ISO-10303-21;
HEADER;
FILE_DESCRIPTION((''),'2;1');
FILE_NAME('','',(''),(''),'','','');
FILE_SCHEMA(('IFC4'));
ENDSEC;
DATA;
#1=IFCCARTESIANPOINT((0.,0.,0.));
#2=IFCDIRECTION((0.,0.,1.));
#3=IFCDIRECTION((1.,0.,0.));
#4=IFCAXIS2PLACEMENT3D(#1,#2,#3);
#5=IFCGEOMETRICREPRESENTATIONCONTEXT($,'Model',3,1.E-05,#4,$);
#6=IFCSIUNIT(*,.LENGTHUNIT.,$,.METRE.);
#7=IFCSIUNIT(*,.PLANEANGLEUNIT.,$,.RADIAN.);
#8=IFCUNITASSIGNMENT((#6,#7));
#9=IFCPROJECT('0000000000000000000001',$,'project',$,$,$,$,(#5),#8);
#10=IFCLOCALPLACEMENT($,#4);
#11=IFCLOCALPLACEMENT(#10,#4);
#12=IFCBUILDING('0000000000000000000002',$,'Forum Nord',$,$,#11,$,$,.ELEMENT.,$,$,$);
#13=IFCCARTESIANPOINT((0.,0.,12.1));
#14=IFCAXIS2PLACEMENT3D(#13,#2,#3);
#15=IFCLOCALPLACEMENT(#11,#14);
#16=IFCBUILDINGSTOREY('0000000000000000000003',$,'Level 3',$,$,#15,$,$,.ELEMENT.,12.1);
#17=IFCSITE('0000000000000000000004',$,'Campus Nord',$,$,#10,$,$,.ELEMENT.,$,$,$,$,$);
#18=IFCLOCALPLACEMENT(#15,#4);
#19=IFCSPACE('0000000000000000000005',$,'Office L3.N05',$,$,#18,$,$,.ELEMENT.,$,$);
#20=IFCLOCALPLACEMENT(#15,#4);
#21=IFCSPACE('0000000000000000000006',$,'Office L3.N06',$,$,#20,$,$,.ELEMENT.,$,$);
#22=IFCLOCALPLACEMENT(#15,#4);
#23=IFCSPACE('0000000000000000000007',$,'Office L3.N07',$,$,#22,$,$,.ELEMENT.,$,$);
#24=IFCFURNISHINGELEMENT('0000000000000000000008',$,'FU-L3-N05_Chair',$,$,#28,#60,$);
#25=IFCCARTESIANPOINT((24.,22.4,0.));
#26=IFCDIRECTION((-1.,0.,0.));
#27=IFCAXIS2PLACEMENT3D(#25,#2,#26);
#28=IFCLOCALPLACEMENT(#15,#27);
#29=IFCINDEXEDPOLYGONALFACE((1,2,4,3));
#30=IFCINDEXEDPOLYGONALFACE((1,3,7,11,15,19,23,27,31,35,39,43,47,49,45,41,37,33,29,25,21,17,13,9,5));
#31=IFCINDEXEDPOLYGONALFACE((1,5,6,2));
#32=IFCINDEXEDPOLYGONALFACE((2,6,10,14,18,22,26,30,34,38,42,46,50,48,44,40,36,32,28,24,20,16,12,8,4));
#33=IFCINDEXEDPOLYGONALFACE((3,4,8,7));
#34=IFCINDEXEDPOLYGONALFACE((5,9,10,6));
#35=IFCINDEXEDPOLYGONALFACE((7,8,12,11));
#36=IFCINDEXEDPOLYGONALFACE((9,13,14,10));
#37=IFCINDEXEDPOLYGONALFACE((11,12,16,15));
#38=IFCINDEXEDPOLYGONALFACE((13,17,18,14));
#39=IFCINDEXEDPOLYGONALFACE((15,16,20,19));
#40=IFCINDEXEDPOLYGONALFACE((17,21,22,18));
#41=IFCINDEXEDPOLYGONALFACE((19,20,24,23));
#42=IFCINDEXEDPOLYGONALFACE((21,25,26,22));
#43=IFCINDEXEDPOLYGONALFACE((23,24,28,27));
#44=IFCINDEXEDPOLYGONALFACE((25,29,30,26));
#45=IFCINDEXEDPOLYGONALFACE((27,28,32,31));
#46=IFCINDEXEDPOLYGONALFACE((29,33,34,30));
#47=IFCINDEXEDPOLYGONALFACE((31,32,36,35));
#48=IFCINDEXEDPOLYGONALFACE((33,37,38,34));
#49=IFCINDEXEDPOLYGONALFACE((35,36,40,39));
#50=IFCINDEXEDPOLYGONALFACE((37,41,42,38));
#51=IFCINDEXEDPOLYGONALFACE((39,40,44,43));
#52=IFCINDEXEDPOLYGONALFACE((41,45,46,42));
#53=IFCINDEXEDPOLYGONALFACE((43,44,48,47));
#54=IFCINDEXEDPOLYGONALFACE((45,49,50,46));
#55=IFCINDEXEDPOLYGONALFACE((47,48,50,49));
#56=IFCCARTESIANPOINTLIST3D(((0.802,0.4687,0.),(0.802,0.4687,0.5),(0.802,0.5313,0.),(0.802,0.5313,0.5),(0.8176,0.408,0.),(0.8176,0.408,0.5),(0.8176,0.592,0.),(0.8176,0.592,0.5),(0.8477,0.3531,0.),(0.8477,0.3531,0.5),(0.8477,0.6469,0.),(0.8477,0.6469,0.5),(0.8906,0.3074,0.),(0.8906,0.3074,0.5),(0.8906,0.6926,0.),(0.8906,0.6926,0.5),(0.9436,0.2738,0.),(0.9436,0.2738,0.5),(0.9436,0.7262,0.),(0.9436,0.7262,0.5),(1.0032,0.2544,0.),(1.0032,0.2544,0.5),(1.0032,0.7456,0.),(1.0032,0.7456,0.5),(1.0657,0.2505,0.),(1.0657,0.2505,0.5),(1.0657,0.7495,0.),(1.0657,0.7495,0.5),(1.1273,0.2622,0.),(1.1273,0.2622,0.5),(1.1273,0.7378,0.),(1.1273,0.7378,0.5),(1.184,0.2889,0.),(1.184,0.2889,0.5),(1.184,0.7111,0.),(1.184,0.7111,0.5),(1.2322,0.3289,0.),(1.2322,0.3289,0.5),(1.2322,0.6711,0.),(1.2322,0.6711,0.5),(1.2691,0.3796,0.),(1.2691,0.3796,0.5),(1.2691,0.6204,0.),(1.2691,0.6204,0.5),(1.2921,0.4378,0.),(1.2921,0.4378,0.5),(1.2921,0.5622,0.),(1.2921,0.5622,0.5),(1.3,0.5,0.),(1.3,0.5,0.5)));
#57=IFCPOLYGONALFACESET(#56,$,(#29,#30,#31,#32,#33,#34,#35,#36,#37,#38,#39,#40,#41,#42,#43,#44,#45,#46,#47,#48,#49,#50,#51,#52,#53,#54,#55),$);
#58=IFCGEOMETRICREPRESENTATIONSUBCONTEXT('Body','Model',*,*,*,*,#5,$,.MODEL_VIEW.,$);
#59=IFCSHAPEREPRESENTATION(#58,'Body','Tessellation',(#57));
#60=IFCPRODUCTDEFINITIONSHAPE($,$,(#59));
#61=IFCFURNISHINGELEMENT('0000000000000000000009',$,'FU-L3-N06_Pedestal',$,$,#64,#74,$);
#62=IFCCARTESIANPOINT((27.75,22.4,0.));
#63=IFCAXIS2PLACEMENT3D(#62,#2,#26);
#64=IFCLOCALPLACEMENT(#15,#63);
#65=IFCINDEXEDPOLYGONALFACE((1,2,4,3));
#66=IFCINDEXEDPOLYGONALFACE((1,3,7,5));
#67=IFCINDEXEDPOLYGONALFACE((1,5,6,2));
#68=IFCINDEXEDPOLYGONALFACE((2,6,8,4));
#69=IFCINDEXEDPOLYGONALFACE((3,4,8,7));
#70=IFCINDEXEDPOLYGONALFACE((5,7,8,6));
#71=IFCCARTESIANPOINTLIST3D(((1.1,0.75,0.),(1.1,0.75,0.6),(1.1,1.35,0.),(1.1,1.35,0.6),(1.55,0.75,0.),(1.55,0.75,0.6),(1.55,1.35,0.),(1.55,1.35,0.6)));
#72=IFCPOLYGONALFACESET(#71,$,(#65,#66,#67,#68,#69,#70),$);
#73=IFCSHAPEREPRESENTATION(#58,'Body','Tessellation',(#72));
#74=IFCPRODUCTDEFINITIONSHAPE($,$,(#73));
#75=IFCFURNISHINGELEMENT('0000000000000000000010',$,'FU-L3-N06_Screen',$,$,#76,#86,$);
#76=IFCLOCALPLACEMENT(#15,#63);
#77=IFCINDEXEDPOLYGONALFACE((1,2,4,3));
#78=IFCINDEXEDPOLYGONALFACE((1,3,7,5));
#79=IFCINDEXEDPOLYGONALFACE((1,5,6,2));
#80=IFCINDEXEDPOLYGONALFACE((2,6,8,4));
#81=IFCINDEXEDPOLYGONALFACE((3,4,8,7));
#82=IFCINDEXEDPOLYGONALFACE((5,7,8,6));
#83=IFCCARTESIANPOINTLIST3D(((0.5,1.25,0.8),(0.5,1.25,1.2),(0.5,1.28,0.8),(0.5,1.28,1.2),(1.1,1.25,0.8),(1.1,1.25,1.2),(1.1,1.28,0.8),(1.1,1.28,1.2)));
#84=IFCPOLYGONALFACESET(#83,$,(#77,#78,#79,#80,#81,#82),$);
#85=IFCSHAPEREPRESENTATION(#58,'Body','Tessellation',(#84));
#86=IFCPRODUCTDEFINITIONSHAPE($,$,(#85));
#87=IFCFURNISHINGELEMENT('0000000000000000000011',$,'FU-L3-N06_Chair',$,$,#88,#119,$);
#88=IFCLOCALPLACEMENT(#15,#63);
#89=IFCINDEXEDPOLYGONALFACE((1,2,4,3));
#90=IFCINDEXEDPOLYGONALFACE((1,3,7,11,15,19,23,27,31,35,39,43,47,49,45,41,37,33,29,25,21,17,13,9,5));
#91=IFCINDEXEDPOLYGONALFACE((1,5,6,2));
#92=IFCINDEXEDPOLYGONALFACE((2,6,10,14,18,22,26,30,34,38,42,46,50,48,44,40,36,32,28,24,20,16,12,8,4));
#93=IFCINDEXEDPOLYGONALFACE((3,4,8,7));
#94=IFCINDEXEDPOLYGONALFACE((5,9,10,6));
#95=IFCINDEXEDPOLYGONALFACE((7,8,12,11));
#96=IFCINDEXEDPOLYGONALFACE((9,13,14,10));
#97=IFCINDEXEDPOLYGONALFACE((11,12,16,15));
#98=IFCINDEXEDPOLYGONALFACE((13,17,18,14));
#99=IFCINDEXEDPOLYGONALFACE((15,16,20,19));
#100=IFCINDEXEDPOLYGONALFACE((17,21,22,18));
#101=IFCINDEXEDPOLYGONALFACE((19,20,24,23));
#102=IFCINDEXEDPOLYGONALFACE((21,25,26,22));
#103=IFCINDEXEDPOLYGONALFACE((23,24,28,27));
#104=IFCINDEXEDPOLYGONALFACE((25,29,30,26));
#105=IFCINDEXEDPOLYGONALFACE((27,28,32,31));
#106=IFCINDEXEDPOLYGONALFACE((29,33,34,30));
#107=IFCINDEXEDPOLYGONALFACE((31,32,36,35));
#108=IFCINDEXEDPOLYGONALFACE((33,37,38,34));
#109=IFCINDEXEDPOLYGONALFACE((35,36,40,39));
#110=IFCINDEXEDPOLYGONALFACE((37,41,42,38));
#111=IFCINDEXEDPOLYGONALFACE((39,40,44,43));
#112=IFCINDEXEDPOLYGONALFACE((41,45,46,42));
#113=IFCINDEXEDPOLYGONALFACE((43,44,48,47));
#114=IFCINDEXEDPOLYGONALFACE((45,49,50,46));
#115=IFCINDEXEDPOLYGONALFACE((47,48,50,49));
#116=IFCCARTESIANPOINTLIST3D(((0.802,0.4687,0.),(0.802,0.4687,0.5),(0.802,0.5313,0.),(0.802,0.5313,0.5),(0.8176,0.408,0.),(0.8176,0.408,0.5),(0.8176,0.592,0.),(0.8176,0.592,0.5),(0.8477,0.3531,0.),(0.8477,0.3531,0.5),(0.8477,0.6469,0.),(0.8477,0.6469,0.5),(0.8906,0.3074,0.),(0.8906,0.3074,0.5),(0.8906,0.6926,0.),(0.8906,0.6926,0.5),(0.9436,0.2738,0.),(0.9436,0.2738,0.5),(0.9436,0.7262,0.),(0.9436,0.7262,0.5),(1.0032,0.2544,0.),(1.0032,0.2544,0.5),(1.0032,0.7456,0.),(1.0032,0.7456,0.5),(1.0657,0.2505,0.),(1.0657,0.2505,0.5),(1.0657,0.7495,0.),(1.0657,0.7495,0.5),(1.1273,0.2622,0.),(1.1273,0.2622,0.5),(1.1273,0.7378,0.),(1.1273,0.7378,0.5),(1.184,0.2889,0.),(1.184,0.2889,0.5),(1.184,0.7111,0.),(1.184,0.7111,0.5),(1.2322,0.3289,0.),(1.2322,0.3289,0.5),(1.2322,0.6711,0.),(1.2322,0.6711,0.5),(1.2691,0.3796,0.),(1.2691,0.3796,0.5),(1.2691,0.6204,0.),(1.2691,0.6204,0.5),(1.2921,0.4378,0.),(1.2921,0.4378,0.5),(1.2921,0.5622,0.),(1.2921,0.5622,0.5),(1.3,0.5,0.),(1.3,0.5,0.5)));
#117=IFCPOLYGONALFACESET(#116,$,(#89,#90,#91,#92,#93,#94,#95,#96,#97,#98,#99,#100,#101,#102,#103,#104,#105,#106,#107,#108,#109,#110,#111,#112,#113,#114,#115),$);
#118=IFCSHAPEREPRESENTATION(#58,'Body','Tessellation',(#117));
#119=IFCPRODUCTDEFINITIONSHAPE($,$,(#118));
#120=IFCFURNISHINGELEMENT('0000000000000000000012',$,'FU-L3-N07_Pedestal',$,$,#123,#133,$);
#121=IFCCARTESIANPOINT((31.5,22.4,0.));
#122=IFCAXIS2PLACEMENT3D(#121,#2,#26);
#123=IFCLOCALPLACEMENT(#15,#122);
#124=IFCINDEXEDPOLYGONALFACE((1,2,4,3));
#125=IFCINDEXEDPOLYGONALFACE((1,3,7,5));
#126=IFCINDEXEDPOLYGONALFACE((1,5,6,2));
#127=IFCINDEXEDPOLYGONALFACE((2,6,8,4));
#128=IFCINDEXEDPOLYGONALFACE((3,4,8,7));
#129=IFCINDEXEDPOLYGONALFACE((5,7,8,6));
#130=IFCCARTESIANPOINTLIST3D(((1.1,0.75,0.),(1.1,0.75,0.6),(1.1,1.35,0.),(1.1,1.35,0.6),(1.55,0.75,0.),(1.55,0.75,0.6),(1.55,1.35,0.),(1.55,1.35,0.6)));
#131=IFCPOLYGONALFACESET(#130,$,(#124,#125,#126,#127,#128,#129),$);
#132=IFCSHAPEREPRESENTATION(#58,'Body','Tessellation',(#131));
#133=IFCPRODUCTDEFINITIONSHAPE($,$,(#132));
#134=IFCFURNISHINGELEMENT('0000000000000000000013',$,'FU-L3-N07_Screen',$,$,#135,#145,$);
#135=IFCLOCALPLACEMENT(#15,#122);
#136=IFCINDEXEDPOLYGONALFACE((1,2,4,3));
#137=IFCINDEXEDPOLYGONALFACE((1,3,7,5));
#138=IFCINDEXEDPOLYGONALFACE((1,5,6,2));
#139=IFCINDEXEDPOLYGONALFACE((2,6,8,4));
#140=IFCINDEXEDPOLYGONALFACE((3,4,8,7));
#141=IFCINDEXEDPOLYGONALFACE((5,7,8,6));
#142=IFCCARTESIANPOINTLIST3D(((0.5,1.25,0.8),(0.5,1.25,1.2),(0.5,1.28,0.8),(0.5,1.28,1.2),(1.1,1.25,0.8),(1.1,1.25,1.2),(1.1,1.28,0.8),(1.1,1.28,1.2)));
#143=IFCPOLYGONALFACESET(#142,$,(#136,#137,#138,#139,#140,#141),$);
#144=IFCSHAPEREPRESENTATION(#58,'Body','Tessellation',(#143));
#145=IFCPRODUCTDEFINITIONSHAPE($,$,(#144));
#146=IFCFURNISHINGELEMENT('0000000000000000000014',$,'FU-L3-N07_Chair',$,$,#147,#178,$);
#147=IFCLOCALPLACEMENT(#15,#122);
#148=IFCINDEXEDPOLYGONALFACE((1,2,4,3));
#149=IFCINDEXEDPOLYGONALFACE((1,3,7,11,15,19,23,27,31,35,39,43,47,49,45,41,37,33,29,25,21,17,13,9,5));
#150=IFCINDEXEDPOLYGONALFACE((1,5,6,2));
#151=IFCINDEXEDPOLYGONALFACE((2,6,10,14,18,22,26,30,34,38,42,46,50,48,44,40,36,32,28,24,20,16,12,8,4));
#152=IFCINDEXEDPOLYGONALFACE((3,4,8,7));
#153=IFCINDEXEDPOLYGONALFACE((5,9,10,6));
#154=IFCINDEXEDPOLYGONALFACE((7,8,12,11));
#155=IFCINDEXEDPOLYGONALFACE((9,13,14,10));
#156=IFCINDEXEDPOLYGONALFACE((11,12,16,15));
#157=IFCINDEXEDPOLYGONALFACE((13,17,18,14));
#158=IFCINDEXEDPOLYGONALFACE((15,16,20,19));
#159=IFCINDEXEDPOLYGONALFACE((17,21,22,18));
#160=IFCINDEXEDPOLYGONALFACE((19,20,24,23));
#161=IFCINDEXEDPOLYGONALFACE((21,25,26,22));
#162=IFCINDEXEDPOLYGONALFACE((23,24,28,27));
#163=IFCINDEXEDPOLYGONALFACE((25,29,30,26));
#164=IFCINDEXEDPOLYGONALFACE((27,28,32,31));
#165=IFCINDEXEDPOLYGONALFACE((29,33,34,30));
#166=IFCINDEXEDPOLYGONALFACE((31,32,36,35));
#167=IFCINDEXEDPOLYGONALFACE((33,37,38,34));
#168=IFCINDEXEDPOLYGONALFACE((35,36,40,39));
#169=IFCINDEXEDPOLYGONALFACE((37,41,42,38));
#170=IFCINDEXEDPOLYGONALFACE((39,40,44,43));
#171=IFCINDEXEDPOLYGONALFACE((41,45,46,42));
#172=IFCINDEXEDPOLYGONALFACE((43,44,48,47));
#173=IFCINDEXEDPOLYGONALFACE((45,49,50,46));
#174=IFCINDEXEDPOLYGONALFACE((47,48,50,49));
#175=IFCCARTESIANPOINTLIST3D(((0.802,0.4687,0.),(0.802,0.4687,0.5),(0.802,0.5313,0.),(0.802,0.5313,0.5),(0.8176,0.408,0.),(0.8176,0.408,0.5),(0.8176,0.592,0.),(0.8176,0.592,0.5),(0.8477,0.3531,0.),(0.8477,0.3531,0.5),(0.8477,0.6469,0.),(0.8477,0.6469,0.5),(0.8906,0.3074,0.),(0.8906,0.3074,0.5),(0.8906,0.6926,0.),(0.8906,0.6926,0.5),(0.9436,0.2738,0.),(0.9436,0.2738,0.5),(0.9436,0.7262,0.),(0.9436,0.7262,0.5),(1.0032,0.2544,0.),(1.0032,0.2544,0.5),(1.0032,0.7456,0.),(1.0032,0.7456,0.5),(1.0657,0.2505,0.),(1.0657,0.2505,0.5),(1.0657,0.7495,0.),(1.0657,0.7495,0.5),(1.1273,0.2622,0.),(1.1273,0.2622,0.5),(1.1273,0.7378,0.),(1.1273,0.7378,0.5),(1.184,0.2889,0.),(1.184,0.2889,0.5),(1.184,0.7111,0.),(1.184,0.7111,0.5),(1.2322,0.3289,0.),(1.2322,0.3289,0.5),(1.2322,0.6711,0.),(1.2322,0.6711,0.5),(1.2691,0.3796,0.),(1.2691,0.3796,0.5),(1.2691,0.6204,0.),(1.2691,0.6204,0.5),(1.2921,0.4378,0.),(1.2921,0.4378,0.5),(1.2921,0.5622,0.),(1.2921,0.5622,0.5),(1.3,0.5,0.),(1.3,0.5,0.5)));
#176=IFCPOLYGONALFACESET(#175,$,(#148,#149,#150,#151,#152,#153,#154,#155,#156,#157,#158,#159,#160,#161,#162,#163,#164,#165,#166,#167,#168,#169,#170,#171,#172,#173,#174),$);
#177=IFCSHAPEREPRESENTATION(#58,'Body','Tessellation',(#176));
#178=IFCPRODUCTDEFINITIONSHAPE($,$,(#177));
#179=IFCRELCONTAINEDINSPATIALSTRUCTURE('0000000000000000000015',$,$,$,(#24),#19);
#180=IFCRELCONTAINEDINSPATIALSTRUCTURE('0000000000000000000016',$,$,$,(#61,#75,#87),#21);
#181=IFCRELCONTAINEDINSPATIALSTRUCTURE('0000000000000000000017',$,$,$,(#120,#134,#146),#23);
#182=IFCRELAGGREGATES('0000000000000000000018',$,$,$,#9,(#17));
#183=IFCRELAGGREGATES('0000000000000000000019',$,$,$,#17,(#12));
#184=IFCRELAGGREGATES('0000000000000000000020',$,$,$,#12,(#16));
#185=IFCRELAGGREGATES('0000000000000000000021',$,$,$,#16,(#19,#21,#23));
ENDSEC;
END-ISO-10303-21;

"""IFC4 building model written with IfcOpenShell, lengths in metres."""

from ifc_helpers import new_model, si_unit, frame, frame_2d, origin_with_axes, place, context, subcontext, project, spatial, rectangle, circle, extrude, element, save


model = new_model("IFC4")

# Units and contexts
model_context = context("Model", 3, precision=1e-05, world=origin_with_axes())
body_context = subcontext(model_context, "Body", "Model", "MODEL_VIEW")
ifc_project = project(units=[si_unit("LENGTHUNIT", "METRE"), si_unit("PLANEANGLEUNIT", "RADIAN")], contexts=[model_context])

# Site, building, storey
site_placement = place(None, origin_with_axes())
site = spatial("IfcSite", under=ifc_project, at=site_placement, Name="Campus Nord", CompositionType="ELEMENT")
building_placement = place(site_placement, origin_with_axes())
building = spatial("IfcBuilding", under=site, at=building_placement, Name="Forum Nord", CompositionType="ELEMENT")
storey_placement = place(building_placement, frame((0.0, 0.0, 12.1), z_axis=(0.0, 0.0, 1.0), x_axis=(1.0, 0.0, 0.0)))
storey = spatial("IfcBuildingStorey", under=building, at=storey_placement, Name="Level 3", CompositionType="ELEMENT", Elevation=12.1)

# Shared definitions
space_1_placement = place(storey_placement, origin_with_axes())
space_1 = spatial("IfcSpace", under=storey, at=space_1_placement, Name="Office L3.N05", CompositionType="ELEMENT")

# Furnishing element
furnishing_1_placement = place(storey_placement, frame((24.0, 22.4, 0.0), z_axis=(0.0, 0.0, 1.0), x_axis=(-1.0, 0.0, 0.0)))
element("IfcFurnishingElement", 1, at=furnishing_1_placement, inside=space_1, Name="FU-L3-N05_Chair", context=body_context, shape_type="SweptSolid", body=[
    extrude(circle(Radius=0.25, at=frame_2d((1.05, 0.5), x_axis=(1.0, 0.0))), origin_with_axes(), (0.0, 0.0, 1.0), 0.5),
])

# Shared definitions
space_2_placement = place(storey_placement, origin_with_axes())
space_2 = spatial("IfcSpace", under=storey, at=space_2_placement, Name="Office L3.N06", CompositionType="ELEMENT")

# Furnishing elements
furnishing_2_placement = place(storey_placement, frame((27.75, 22.4, 0.0), z_axis=(0.0, 0.0, 1.0), x_axis=(-1.0, 0.0, 0.0)))
element("IfcFurnishingElement", 2, at=furnishing_2_placement, inside=space_2, Name="FU-L3-N06_Pedestal", context=body_context, shape_type="SweptSolid", body=[
    extrude(rectangle(XDim=0.45, YDim=0.6, at=frame_2d((1.325, 1.05), x_axis=(1.0, 0.0))), origin_with_axes(), (0.0, 0.0, 1.0), 0.6),
])
furnishing_3_placement = place(storey_placement, frame((27.75, 22.4, 0.0), z_axis=(0.0, 0.0, 1.0), x_axis=(-1.0, 0.0, 0.0)))
element("IfcFurnishingElement", 3, at=furnishing_3_placement, inside=space_2, Name="FU-L3-N06_Screen", context=body_context, shape_type="SweptSolid", body=[
    extrude(rectangle(XDim=0.6, YDim=0.03, at=frame_2d((0.8, 1.265), x_axis=(1.0, 0.0))), frame((0.0, 0.0, 0.8), z_axis=(0.0, 0.0, 1.0), x_axis=(1.0, 0.0, 0.0)), (0.0, 0.0, 1.0), 0.4),
])
furnishing_4_placement = place(storey_placement, frame((27.75, 22.4, 0.0), z_axis=(0.0, 0.0, 1.0), x_axis=(-1.0, 0.0, 0.0)))
element("IfcFurnishingElement", 4, at=furnishing_4_placement, inside=space_2, Name="FU-L3-N06_Chair", context=body_context, shape_type="SweptSolid", body=[
    extrude(circle(Radius=0.25, at=frame_2d((1.05, 0.5), x_axis=(1.0, 0.0))), origin_with_axes(), (0.0, 0.0, 1.0), 0.5),
])

# Shared definitions
space_3_placement = place(storey_placement, origin_with_axes())
space_3 = spatial("IfcSpace", under=storey, at=space_3_placement, Name="Office L3.N07", CompositionType="ELEMENT")

# Furnishing elements
furnishing_5_placement = place(storey_placement, frame((31.5, 22.4, 0.0), z_axis=(0.0, 0.0, 1.0), x_axis=(-1.0, 0.0, 0.0)))
element("IfcFurnishingElement", 5, at=furnishing_5_placement, inside=space_3, Name="FU-L3-N07_Pedestal", context=body_context, shape_type="SweptSolid", body=[
    extrude(rectangle(XDim=0.45, YDim=0.6, at=frame_2d((1.325, 1.05), x_axis=(1.0, 0.0))), origin_with_axes(), (0.0, 0.0, 1.0), 0.6),
])
furnishing_6_placement = place(storey_placement, frame((31.5, 22.4, 0.0), z_axis=(0.0, 0.0, 1.0), x_axis=(-1.0, 0.0, 0.0)))
element("IfcFurnishingElement", 6, at=furnishing_6_placement, inside=space_3, Name="FU-L3-N07_Screen", context=body_context, shape_type="SweptSolid", body=[
    extrude(rectangle(XDim=0.6, YDim=0.03, at=frame_2d((0.8, 1.265), x_axis=(1.0, 0.0))), frame((0.0, 0.0, 0.8), z_axis=(0.0, 0.0, 1.0), x_axis=(1.0, 0.0, 0.0)), (0.0, 0.0, 1.0), 0.4),
])
furnishing_7_placement = place(storey_placement, frame((31.5, 22.4, 0.0), z_axis=(0.0, 0.0, 1.0), x_axis=(-1.0, 0.0, 0.0)))
element("IfcFurnishingElement", 7, at=furnishing_7_placement, inside=space_3, Name="FU-L3-N07_Chair", context=body_context, shape_type="SweptSolid", body=[
    extrude(circle(Radius=0.25, at=frame_2d((1.05, 0.5), x_axis=(1.0, 0.0))), origin_with_axes(), (0.0, 0.0, 1.0), 0.5),
])

save(model, "model.ifc")
